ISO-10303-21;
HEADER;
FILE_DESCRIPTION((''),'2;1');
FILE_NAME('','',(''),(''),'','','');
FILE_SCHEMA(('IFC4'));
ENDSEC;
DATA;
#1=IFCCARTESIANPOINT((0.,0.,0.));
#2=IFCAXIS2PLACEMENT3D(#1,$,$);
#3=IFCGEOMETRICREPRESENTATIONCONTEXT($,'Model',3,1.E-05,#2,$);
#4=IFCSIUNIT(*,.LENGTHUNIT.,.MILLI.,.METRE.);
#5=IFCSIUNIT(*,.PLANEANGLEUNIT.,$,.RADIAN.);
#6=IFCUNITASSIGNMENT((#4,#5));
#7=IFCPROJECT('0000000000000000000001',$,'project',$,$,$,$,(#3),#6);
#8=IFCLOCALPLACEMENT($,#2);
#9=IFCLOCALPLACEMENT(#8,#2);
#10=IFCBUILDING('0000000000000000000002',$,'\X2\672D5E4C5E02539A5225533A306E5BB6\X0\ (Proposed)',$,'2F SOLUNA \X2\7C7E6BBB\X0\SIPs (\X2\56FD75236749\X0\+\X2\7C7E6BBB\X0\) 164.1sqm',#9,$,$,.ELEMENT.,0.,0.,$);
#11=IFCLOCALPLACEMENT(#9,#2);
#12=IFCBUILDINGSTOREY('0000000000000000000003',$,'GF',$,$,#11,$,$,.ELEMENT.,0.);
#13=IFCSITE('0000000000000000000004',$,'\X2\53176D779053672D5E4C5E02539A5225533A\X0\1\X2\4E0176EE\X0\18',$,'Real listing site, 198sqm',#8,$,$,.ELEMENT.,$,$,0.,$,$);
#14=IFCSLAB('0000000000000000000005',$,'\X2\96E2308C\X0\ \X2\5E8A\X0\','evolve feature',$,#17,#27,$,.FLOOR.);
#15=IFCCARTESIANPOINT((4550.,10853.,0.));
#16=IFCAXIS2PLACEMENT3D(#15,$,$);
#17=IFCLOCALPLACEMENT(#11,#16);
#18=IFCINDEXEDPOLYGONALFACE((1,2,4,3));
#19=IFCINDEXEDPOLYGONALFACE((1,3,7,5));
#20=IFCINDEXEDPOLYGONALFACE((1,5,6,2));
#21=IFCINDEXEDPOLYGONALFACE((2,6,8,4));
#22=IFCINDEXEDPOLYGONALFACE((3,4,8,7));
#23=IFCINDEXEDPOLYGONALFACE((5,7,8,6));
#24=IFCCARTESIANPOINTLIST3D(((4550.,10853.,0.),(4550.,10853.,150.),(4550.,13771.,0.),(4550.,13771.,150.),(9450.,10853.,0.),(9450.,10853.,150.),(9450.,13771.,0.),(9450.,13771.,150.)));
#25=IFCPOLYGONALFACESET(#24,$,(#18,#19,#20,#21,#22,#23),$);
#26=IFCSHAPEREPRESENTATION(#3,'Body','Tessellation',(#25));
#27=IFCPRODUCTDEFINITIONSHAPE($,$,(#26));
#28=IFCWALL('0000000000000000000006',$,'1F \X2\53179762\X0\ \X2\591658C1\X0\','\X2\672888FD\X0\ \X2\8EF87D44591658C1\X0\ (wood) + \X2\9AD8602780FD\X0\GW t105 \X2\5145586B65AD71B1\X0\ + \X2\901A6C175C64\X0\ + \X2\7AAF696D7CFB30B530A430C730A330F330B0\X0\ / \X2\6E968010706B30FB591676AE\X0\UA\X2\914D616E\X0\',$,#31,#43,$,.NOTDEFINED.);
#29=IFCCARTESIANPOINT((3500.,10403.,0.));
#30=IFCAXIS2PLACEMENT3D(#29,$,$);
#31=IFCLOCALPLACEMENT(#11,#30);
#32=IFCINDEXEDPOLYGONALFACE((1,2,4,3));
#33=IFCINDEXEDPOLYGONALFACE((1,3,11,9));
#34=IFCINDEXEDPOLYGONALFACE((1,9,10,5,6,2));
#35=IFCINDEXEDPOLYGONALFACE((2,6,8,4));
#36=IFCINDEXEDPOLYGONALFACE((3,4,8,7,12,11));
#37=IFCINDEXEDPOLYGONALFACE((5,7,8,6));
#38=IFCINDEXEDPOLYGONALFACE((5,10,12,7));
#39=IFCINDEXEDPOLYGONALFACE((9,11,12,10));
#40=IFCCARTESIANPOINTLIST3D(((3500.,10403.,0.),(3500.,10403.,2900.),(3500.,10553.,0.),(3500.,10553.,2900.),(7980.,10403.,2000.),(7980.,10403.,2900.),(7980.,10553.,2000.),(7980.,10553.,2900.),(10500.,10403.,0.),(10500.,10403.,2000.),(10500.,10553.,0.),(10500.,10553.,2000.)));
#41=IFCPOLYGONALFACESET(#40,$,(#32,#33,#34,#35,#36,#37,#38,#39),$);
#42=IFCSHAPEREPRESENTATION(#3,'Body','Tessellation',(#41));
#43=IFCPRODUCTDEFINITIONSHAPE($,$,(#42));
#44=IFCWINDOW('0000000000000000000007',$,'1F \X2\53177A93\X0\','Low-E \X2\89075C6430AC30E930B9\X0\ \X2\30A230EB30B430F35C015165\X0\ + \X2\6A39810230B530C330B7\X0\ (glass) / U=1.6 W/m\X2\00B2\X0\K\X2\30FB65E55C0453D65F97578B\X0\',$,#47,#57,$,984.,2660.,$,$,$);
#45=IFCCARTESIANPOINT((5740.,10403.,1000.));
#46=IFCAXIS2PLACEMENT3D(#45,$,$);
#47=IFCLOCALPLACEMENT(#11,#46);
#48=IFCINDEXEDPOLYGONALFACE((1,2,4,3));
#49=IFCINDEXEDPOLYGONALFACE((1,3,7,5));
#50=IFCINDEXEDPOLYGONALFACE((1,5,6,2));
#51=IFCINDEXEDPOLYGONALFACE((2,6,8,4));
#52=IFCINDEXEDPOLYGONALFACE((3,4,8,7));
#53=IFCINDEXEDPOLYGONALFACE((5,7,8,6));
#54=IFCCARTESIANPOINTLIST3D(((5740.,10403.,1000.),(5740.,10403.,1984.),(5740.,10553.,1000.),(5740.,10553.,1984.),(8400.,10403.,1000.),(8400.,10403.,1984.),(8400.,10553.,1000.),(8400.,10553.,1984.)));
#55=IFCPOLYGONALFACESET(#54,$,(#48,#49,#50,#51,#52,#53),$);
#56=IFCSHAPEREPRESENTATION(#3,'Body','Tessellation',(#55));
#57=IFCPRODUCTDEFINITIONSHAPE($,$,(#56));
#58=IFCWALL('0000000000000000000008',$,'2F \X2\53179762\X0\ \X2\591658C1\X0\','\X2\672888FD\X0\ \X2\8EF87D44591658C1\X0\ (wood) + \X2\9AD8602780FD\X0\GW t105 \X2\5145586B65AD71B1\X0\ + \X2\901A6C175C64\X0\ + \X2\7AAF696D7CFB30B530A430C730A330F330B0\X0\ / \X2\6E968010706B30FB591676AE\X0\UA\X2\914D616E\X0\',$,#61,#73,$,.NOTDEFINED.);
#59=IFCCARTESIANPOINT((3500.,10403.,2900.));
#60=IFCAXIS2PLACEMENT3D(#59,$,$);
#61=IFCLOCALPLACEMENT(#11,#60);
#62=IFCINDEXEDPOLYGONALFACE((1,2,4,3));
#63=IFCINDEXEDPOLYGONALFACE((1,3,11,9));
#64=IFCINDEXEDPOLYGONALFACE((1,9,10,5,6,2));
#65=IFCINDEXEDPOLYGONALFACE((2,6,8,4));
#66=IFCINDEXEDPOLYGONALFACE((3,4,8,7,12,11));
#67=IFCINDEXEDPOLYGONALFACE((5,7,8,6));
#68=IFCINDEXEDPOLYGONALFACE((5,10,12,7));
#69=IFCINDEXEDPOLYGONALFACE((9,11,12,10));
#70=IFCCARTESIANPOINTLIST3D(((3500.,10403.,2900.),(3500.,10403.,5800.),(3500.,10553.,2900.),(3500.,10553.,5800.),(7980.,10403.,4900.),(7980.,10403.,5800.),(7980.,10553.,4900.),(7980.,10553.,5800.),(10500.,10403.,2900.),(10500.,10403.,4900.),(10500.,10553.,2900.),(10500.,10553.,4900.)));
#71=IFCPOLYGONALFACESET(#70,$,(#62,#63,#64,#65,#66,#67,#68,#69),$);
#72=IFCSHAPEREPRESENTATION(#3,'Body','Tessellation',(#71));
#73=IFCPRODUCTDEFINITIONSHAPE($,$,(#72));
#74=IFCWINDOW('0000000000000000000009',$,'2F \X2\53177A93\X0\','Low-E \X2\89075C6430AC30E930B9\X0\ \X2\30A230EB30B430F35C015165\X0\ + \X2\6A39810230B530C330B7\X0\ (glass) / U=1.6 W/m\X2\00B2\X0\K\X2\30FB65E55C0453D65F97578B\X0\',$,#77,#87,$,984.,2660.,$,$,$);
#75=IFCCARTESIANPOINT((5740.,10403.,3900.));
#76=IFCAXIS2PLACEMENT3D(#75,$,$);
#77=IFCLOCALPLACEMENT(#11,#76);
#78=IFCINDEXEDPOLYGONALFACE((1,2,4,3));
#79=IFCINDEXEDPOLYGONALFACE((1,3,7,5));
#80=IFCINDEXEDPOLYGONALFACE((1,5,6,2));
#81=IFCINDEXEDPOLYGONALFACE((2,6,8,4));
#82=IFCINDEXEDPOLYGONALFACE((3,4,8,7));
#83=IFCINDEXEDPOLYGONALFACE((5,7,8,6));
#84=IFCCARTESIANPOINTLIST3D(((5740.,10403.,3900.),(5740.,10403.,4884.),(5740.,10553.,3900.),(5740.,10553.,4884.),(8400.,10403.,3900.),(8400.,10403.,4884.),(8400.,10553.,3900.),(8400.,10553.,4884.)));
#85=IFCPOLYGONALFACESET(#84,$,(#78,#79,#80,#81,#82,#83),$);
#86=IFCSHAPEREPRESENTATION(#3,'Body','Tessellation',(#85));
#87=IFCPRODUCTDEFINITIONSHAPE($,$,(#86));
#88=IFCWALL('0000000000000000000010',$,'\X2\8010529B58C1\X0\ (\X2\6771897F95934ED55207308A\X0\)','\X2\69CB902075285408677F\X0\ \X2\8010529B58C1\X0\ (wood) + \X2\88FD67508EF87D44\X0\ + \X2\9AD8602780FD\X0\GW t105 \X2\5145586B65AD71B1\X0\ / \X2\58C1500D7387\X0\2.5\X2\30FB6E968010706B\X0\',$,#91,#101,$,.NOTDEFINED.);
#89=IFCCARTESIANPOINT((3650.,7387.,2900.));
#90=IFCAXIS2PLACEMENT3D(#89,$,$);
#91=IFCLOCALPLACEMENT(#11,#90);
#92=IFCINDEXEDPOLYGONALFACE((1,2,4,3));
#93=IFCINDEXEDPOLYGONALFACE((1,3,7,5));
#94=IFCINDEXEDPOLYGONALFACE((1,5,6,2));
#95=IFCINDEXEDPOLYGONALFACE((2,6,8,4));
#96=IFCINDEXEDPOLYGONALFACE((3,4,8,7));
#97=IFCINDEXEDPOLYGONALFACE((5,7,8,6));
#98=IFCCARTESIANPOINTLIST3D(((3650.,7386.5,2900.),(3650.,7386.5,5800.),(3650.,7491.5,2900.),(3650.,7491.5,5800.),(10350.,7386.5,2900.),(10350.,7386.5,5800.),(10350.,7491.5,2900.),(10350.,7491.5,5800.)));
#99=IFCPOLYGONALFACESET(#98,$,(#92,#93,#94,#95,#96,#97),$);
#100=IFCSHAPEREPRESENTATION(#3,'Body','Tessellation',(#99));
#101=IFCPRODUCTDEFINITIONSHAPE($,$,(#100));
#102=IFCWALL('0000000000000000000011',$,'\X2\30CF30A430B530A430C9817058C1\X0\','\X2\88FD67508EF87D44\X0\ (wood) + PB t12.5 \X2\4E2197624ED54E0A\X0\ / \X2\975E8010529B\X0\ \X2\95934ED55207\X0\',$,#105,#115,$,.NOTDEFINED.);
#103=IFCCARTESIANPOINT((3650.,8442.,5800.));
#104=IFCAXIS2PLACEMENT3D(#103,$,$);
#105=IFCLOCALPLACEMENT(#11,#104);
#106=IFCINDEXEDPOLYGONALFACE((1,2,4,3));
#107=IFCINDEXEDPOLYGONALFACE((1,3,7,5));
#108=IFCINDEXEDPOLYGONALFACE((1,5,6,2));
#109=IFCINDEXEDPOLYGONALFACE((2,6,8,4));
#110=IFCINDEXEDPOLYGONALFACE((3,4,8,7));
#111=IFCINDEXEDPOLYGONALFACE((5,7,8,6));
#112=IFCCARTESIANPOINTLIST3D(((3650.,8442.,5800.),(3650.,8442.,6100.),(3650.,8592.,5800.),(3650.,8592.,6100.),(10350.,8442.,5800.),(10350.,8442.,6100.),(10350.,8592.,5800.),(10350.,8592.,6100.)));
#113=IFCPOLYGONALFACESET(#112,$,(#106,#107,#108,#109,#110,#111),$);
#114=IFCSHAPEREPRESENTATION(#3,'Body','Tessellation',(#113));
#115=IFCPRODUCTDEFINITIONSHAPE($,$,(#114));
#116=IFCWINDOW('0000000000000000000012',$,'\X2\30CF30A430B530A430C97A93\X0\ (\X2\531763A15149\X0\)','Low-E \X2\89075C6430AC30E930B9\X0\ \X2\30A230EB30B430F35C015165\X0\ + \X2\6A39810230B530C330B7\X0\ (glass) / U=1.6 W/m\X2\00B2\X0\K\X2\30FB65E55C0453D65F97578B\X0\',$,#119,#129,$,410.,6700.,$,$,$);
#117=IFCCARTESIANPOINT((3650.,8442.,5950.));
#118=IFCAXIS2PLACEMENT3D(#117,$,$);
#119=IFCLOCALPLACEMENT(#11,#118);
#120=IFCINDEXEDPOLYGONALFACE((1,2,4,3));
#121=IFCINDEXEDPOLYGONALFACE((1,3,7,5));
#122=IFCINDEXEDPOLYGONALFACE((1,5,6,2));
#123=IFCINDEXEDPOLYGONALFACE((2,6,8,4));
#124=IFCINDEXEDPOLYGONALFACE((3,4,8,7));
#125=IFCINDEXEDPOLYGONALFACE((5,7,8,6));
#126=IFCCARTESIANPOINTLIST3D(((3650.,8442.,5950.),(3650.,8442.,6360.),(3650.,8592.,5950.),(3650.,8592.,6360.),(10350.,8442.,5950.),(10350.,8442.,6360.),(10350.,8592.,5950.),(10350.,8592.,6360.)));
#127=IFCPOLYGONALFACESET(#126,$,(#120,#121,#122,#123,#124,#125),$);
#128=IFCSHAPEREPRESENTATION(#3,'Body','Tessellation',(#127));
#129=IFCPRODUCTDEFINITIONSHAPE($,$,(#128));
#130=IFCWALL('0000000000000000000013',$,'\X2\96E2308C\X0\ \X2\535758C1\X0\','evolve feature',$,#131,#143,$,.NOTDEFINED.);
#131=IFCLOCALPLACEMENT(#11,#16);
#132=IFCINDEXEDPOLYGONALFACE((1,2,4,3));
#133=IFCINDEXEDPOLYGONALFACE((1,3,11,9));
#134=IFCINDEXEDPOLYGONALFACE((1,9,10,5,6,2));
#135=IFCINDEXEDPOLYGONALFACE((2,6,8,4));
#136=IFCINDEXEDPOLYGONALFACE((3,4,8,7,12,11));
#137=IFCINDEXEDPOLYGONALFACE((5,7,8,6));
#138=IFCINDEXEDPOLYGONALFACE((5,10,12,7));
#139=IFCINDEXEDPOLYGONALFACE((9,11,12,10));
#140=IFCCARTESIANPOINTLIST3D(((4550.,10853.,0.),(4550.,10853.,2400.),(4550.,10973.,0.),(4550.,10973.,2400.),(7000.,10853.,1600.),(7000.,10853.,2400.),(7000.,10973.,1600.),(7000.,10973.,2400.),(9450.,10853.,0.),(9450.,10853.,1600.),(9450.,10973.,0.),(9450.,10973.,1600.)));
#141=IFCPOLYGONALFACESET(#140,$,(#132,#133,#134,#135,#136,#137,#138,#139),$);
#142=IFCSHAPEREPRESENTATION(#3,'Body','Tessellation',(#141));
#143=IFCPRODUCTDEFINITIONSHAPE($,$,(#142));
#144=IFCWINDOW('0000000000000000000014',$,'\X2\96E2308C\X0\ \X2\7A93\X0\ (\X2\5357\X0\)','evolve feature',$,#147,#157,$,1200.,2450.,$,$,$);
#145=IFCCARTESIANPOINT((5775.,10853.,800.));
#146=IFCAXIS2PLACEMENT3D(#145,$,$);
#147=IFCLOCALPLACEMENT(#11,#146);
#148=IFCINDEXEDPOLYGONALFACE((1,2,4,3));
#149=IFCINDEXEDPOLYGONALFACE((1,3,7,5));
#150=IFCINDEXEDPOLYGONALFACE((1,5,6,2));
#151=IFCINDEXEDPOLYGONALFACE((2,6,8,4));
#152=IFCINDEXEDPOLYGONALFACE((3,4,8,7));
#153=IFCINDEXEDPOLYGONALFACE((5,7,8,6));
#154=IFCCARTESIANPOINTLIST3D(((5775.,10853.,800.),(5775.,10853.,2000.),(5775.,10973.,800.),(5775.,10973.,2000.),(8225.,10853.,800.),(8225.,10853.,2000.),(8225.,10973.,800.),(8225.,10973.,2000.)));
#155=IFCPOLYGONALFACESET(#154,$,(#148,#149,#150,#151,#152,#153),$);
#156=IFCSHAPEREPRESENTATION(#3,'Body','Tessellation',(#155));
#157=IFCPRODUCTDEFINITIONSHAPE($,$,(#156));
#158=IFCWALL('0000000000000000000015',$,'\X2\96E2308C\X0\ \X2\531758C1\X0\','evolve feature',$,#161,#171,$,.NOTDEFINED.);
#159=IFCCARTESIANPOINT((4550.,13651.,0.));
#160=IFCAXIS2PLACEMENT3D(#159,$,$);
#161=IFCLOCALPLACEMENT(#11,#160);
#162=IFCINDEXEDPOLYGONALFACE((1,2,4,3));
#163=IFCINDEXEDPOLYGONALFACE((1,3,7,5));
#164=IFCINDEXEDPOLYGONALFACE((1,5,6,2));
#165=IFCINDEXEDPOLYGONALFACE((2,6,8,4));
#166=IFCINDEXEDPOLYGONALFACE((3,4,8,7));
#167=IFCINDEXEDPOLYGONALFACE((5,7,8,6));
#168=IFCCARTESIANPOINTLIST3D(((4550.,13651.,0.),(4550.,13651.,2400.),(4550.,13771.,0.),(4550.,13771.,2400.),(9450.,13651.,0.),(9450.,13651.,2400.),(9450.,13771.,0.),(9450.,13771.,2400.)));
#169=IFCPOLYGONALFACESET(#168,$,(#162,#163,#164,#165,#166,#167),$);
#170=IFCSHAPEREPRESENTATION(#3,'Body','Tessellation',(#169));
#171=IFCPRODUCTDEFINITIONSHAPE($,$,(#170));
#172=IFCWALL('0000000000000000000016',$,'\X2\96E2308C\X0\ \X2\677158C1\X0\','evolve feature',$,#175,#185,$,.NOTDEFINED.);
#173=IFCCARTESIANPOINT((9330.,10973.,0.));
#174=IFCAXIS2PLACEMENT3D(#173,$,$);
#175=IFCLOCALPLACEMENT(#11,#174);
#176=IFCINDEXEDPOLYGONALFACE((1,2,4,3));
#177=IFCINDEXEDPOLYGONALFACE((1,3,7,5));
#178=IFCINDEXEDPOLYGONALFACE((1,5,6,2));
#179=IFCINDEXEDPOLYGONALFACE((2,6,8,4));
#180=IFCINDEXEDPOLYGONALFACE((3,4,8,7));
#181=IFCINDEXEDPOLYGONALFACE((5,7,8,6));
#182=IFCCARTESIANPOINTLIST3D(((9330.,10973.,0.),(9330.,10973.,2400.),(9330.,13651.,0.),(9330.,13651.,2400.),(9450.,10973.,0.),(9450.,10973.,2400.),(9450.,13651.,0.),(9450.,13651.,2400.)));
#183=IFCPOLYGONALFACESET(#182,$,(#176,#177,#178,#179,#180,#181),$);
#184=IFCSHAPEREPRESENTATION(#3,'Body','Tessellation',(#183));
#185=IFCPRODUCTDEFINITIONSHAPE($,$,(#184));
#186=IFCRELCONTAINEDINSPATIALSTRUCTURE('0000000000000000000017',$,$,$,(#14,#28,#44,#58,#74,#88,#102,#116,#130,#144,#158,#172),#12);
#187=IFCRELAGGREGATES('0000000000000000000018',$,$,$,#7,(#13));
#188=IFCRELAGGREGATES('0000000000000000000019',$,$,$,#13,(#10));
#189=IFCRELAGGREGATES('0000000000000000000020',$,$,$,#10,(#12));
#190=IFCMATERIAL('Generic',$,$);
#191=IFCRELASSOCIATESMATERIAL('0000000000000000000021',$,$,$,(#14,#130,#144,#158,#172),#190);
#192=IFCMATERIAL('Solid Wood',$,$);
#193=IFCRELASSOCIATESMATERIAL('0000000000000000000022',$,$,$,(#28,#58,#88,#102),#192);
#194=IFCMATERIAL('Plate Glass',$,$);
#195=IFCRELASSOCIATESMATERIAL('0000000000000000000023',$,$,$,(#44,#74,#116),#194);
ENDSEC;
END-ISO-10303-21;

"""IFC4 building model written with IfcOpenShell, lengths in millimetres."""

from ifc_helpers import new_model, si_unit, frame, frame_2d, origin, place, context, project, spatial, rectangle, extrude, material, element, fill, save


model = new_model("IFC4")

# Units and contexts
model_context = context("Model", 3, precision=1e-05, world=origin())
ifc_project = project(units=[si_unit("LENGTHUNIT", "METRE", prefix="MILLI"), si_unit("PLANEANGLEUNIT", "RADIAN")], contexts=[model_context])

# Site, building, storey
site_placement = place(None, origin())
site = spatial("IfcSite", under=ifc_project, at=site_placement, Name="北海道札幌市厚別区1丁目18", ObjectType="Real listing site, 198sqm", CompositionType="ELEMENT", RefElevation=0.0)
building_placement = place(site_placement, origin())
building = spatial("IfcBuilding", under=site, at=building_placement, Name="札幌市厚別区の家 (Proposed)", ObjectType="2F SOLUNA 籾殻SIPs (国産杉+籾殻) 164.1sqm", CompositionType="ELEMENT", ElevationOfRefHeight=0.0, ElevationOfTerrain=0.0)
storey_placement = place(building_placement, origin())
storey = spatial("IfcBuildingStorey", under=building, at=storey_placement, Name="GF", CompositionType="ELEMENT", Elevation=0.0)

# Slab
ifc_material_1 = material(Name="Generic")
slab_placement = place(storey_placement, frame((4550.0, 10853.0, 0.0)))
element("IfcSlab", 1, at=slab_placement, inside=storey, material=ifc_material_1, Name="離れ 床", Description="evolve feature", PredefinedType="FLOOR", context=model_context, shape_type="SweptSolid", body=[
    extrude(rectangle(XDim=4900.0, YDim=2918.0, at=frame_2d((2450.0, 1459.0))), frame((4550.0, 10853.0, 0.0)), (0.0, 0.0, 1.0), 150.0),
])

# Wall, opening, window
ifc_material_2 = material(Name="Solid Wood")
wall_1_placement = place(storey_placement, frame((3500.0, 10403.0, 0.0)))
wall_1 = element("IfcWall", 2, at=wall_1_placement, inside=storey, material=ifc_material_2, Name="1F 北面 外壁", Description="木製 軸組外壁 (wood) + 高性能GW t105 充填断熱 + 通気層 + 窯業系サイディング / 準耐火・外皮UA配慮", PredefinedType="NOTDEFINED", context=model_context, shape_type="SweptSolid", body=[
    extrude(rectangle(XDim=7000.0, YDim=150.0, at=frame_2d((3500.0, 75.0))), frame((3500.0, 10403.0, 0.0)), (0.0, 0.0, 1.0), 2900.0),
])
opening_1_placement = place(storey_placement, frame((5740.0, 10403.0, 1000.0)))
opening_1 = element("IfcOpeningElement", 3, at=opening_1_placement, cuts=wall_1, PredefinedType="NOTDEFINED", context=model_context, shape_type="SweptSolid", body=[
    extrude(rectangle(XDim=2660.0, YDim=150.0, at=frame_2d((1330.0, 75.0))), frame((5740.0, 10403.0, 1000.0)), (0.0, 0.0, 1.0), 984.0),
])
ifc_material_3 = material(Name="Plate Glass")
window_1_placement = place(storey_placement, frame((5740.0, 10403.0, 1000.0)))
window_1 = element("IfcWindow", 4, at=window_1_placement, inside=storey, material=ifc_material_3, Name="1F 北窓", Description="Low-E 複層ガラス アルゴン封入 + 樹脂サッシ (glass) / U=1.6 W/m²K・日射取得型", OverallHeight=984.0, OverallWidth=2660.0, context=model_context, shape_type="SweptSolid", body=[
    extrude(rectangle(XDim=2660.0, YDim=150.0, at=frame_2d((1330.0, 75.0))), frame((5740.0, 10403.0, 1000.0)), (0.0, 0.0, 1.0), 984.0),
])
fill(opening_1, window_1)

# Wall, opening, window
wall_2_placement = place(storey_placement, frame((3500.0, 10403.0, 2900.0)))
wall_2 = element("IfcWall", 5, at=wall_2_placement, inside=storey, material=ifc_material_2, Name="2F 北面 外壁", Description="木製 軸組外壁 (wood) + 高性能GW t105 充填断熱 + 通気層 + 窯業系サイディング / 準耐火・外皮UA配慮", PredefinedType="NOTDEFINED", context=model_context, shape_type="SweptSolid", body=[
    extrude(rectangle(XDim=7000.0, YDim=150.0, at=frame_2d((3500.0, 75.0))), frame((3500.0, 10403.0, 2900.0)), (0.0, 0.0, 1.0), 2900.0),
])
opening_2_placement = place(storey_placement, frame((5740.0, 10403.0, 3900.0)))
opening_2 = element("IfcOpeningElement", 6, at=opening_2_placement, cuts=wall_2, PredefinedType="NOTDEFINED", context=model_context, shape_type="SweptSolid", body=[
    extrude(rectangle(XDim=2660.0, YDim=150.0, at=frame_2d((1330.0, 75.0))), frame((5740.0, 10403.0, 3900.0)), (0.0, 0.0, 1.0), 984.0),
])
window_2_placement = place(storey_placement, frame((5740.0, 10403.0, 3900.0)))
window_2 = element("IfcWindow", 7, at=window_2_placement, inside=storey, material=ifc_material_3, Name="2F 北窓", Description="Low-E 複層ガラス アルゴン封入 + 樹脂サッシ (glass) / U=1.6 W/m²K・日射取得型", OverallHeight=984.0, OverallWidth=2660.0, context=model_context, shape_type="SweptSolid", body=[
    extrude(rectangle(XDim=2660.0, YDim=150.0, at=frame_2d((1330.0, 75.0))), frame((5740.0, 10403.0, 3900.0)), (0.0, 0.0, 1.0), 984.0),
])
fill(opening_2, window_2)

# Wall
wall_3_placement = place(storey_placement, frame((3650.0, 7387.0, 2900.0)))
element("IfcWall", 8, at=wall_3_placement, inside=storey, material=ifc_material_2, Name="耐力壁 (東西間仕切り)", Description="構造用合板 耐力壁 (wood) + 製材軸組 + 高性能GW t105 充填断熱 / 壁倍率2.5・準耐火", PredefinedType="NOTDEFINED", context=model_context, shape_type="SweptSolid", body=[
    extrude(rectangle(XDim=6700.0, YDim=105.0, at=frame_2d((3350.0, 52.0))), frame((3650.0, 7387.0, 2900.0)), (0.0, 0.0, 1.0), 2900.0),
])

# Walls, openings, windows
wall_4_placement = place(storey_placement, frame((3650.0, 8442.0, 5800.0)))
wall_4 = element("IfcWall", 9, at=wall_4_placement, inside=storey, material=ifc_material_2, Name="ハイサイド腰壁", Description="製材軸組 (wood) + PB t12.5 両面仕上 / 非耐力 間仕切", PredefinedType="NOTDEFINED", context=model_context, shape_type="SweptSolid", body=[
    extrude(rectangle(XDim=6700.0, YDim=150.0, at=frame_2d((3350.0, 75.0))), frame((3650.0, 8442.0, 5800.0)), (0.0, 0.0, 1.0), 700.0),
])
opening_3_placement = place(storey_placement, frame((3650.0, 8442.0, 5950.0)))
opening_3 = element("IfcOpeningElement", 10, at=opening_3_placement, cuts=wall_4, PredefinedType="NOTDEFINED", context=model_context, shape_type="SweptSolid", body=[
    extrude(rectangle(XDim=6700.0, YDim=150.0, at=frame_2d((3350.0, 75.0))), frame((3650.0, 8442.0, 5950.0)), (0.0, 0.0, 1.0), 410.0),
])
window_3_placement = place(storey_placement, frame((3650.0, 8442.0, 5950.0)))
window_3 = element("IfcWindow", 11, at=window_3_placement, inside=storey, material=ifc_material_3, Name="ハイサイド窓 (北採光)", Description="Low-E 複層ガラス アルゴン封入 + 樹脂サッシ (glass) / U=1.6 W/m²K・日射取得型", OverallHeight=410.0, OverallWidth=6700.0, context=model_context, shape_type="SweptSolid", body=[
    extrude(rectangle(XDim=6700.0, YDim=150.0, at=frame_2d((3350.0, 75.0))), frame((3650.0, 8442.0, 5950.0)), (0.0, 0.0, 1.0), 410.0),
])
fill(opening_3, window_3)
wall_5_placement = place(storey_placement, frame((4550.0, 10853.0, 0.0)))
wall_5 = element("IfcWall", 12, at=wall_5_placement, inside=storey, material=ifc_material_1, Name="離れ 南壁", Description="evolve feature", PredefinedType="NOTDEFINED", context=model_context, shape_type="SweptSolid", body=[
    extrude(rectangle(XDim=4900.0, YDim=120.0, at=frame_2d((2450.0, 60.0))), frame((4550.0, 10853.0, 0.0)), (0.0, 0.0, 1.0), 2400.0),
])
opening_4_placement = place(storey_placement, frame((5775.0, 10853.0, 800.0)))
opening_4 = element("IfcOpeningElement", 13, at=opening_4_placement, cuts=wall_5, PredefinedType="NOTDEFINED", context=model_context, shape_type="SweptSolid", body=[
    extrude(rectangle(XDim=2450.0, YDim=120.0, at=frame_2d((1225.0, 60.0))), frame((5775.0, 10853.0, 800.0)), (0.0, 0.0, 1.0), 1200.0),
])
window_4_placement = place(storey_placement, frame((5775.0, 10853.0, 800.0)))
window_4 = element("IfcWindow", 14, at=window_4_placement, inside=storey, material=ifc_material_1, Name="離れ 窓 (南)", Description="evolve feature", OverallHeight=1200.0, OverallWidth=2450.0, context=model_context, shape_type="SweptSolid", body=[
    extrude(rectangle(XDim=2450.0, YDim=120.0, at=frame_2d((1225.0, 60.0))), frame((5775.0, 10853.0, 800.0)), (0.0, 0.0, 1.0), 1200.0),
])
fill(opening_4, window_4)

# Walls
wall_6_placement = place(storey_placement, frame((4550.0, 13651.0, 0.0)))
element("IfcWall", 15, at=wall_6_placement, inside=storey, material=ifc_material_1, Name="離れ 北壁", Description="evolve feature", PredefinedType="NOTDEFINED", context=model_context, shape_type="SweptSolid", body=[
    extrude(rectangle(XDim=4900.0, YDim=120.0, at=frame_2d((2450.0, 60.0))), frame((4550.0, 13651.0, 0.0)), (0.0, 0.0, 1.0), 2400.0),
])
wall_7_placement = place(storey_placement, frame((9330.0, 10973.0, 0.0)))
element("IfcWall", 16, at=wall_7_placement, inside=storey, material=ifc_material_1, Name="離れ 東壁", Description="evolve feature", PredefinedType="NOTDEFINED", context=model_context, shape_type="SweptSolid", body=[
    extrude(rectangle(XDim=120.0, YDim=2678.0, at=frame_2d((60.0, 1339.0))), frame((9330.0, 10973.0, 0.0)), (0.0, 0.0, 1.0), 2400.0),
])

save(model, "model.ifc")
